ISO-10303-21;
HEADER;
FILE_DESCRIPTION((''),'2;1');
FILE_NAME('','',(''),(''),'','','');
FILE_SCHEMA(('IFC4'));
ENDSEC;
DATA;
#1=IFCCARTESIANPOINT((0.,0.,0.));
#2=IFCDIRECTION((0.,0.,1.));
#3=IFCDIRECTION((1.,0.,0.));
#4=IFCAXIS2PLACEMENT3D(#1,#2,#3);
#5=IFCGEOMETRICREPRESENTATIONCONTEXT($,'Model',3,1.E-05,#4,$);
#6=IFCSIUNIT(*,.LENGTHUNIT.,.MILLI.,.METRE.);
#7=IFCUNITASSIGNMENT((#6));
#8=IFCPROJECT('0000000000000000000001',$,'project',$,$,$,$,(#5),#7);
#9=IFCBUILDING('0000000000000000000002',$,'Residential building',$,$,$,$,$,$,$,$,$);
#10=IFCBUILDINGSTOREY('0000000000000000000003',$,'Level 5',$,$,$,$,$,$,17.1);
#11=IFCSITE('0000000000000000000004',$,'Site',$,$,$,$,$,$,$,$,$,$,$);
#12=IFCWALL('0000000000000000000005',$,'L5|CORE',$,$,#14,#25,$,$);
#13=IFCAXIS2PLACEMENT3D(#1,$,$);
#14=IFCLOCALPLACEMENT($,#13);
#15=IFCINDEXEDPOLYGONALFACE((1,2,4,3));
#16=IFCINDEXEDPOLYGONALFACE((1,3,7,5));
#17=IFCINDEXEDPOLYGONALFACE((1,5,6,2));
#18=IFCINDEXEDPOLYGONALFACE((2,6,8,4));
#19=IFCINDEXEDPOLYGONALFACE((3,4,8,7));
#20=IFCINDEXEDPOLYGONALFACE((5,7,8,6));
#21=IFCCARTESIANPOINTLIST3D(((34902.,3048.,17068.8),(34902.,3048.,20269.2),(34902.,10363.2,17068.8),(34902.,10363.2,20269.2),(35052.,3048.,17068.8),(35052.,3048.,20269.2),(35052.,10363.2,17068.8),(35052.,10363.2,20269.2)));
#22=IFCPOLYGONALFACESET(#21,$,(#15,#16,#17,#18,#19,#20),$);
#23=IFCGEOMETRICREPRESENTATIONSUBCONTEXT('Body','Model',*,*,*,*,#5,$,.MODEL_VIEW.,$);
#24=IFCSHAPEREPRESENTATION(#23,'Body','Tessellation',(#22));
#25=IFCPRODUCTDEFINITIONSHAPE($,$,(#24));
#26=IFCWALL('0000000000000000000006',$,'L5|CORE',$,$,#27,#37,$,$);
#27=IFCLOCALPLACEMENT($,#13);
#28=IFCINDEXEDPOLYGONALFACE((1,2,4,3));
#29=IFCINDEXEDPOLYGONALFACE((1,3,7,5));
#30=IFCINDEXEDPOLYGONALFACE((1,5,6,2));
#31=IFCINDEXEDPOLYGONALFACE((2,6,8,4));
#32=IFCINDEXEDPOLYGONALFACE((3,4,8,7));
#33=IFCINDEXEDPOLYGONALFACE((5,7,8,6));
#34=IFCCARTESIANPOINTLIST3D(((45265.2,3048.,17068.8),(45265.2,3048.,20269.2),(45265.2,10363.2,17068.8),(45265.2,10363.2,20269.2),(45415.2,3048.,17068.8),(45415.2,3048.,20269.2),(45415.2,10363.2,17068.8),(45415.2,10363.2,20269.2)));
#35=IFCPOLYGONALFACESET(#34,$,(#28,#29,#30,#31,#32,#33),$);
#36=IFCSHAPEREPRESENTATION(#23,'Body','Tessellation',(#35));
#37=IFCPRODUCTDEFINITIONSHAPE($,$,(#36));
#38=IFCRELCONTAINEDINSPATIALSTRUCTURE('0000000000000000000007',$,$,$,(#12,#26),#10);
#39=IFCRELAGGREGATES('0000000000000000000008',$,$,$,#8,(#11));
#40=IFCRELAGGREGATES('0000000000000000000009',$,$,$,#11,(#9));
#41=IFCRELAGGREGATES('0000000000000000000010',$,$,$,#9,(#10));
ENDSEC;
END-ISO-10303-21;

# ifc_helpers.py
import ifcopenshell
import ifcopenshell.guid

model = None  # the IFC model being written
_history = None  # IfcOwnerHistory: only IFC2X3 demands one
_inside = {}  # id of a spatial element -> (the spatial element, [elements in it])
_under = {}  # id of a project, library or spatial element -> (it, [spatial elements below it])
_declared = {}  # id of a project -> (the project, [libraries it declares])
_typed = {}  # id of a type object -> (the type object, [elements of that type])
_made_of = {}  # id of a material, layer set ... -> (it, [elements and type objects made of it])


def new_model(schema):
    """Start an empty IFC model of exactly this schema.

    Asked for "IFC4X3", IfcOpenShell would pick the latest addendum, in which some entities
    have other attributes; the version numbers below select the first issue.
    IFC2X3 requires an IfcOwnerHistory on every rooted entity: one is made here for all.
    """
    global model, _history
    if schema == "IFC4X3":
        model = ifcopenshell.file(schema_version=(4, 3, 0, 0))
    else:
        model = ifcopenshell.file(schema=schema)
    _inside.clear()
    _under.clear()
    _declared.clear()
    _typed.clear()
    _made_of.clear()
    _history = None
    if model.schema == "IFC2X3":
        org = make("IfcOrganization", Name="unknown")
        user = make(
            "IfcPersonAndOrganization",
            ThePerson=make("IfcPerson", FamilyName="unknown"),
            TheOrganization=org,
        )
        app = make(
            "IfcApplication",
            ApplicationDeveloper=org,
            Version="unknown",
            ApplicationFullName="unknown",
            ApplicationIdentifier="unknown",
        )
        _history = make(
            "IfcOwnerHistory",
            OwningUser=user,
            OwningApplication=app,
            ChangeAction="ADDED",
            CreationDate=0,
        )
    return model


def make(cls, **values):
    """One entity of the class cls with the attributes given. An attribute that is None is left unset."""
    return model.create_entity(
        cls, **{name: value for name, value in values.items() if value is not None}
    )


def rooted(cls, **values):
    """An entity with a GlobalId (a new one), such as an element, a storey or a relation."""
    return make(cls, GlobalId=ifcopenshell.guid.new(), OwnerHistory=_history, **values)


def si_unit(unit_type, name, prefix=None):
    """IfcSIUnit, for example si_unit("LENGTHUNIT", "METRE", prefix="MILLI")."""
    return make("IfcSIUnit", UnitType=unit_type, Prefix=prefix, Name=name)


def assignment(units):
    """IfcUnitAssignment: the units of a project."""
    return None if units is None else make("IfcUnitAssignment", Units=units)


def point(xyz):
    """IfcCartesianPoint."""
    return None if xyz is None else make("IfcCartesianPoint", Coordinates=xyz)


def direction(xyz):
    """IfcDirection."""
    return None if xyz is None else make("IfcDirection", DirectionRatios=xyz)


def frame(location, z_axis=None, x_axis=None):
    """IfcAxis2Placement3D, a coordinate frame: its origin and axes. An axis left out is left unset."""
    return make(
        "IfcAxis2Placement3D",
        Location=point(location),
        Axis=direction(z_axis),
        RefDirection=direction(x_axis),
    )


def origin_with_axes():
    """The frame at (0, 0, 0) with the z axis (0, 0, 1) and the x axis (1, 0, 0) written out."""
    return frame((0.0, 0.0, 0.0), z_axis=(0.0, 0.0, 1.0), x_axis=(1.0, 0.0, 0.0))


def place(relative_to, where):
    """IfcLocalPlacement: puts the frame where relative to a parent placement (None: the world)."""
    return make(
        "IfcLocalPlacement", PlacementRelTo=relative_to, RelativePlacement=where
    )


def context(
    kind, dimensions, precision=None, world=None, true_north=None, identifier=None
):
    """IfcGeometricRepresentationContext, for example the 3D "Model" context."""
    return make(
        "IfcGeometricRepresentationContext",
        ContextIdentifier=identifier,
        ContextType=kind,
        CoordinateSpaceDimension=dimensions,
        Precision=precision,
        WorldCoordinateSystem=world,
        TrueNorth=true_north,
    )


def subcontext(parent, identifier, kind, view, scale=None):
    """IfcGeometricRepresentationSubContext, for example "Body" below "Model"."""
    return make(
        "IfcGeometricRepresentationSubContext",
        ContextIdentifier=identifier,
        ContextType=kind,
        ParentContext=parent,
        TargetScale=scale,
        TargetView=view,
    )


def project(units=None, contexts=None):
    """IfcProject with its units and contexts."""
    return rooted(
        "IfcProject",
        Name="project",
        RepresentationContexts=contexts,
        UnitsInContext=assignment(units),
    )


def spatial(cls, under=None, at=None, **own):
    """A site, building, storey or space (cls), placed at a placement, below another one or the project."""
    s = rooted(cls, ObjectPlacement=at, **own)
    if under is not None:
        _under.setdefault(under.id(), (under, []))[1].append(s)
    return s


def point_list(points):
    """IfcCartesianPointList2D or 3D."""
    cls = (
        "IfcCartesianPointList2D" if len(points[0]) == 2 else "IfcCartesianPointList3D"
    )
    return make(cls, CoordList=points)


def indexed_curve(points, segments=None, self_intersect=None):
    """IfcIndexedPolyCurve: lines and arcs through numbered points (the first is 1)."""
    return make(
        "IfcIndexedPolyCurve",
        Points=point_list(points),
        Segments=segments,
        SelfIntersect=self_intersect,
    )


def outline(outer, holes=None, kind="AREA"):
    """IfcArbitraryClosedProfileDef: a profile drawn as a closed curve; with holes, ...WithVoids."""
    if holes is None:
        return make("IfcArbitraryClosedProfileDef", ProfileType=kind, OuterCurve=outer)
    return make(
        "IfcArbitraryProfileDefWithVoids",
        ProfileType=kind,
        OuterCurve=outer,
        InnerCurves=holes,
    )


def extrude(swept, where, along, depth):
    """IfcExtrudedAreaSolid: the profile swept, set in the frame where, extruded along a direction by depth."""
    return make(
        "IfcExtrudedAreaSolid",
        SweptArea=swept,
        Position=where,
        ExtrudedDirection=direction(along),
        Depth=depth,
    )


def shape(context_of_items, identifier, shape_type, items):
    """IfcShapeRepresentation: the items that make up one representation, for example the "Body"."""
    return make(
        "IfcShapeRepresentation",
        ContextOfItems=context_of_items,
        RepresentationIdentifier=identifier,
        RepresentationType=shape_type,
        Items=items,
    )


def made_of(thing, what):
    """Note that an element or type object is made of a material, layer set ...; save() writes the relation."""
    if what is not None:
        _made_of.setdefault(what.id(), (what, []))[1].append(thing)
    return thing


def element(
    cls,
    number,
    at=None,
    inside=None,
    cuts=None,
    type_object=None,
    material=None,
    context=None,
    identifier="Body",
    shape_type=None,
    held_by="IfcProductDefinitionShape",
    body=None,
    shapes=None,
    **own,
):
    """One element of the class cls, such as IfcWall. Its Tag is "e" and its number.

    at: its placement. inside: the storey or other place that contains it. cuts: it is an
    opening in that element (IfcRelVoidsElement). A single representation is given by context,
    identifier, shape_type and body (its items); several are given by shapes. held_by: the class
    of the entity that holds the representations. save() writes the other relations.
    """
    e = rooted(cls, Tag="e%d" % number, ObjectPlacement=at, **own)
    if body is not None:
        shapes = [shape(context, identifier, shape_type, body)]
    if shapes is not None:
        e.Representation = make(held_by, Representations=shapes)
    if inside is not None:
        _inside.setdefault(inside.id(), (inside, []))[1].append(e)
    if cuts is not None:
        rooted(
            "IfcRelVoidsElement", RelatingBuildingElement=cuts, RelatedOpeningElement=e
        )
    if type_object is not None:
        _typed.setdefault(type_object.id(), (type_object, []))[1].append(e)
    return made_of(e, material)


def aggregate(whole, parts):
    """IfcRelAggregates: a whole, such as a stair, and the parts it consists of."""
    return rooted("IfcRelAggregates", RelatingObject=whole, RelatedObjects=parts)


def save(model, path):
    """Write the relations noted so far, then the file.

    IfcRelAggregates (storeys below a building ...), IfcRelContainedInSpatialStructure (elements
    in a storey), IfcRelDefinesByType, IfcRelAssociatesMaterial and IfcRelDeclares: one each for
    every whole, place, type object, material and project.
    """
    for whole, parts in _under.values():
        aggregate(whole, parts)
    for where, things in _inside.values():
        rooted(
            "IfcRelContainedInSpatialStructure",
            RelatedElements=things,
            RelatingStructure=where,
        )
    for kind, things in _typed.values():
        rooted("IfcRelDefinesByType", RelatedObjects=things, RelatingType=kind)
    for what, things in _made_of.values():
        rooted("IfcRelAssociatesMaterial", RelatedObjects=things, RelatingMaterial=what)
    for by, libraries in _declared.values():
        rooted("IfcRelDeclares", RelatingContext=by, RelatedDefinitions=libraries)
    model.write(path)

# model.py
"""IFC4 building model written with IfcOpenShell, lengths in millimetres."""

from ifc_helpers import new_model, si_unit, frame, origin_with_axes, place, context, subcontext, project, spatial, indexed_curve, outline, extrude, element, save


model = new_model("IFC4")

# Units and contexts
model_context = context("Model", 3, precision=1e-05, world=origin_with_axes())
body_context = subcontext(model_context, "Body", "Model", "MODEL_VIEW")
ifc_project = project(units=[si_unit("LENGTHUNIT", "METRE", prefix="MILLI")], contexts=[model_context])

# Site, building, storey
site = spatial("IfcSite", under=ifc_project, Name="Site")
building = spatial("IfcBuilding", under=site, Name="Residential building")
storey = spatial("IfcBuildingStorey", under=building, Name="Level 5", Elevation=17.1)

# Walls
for number, where, z_axis, x_axis, name in (
    (1, (35052.0, 3048.0, 17068.8), (0.0, 0.0, 1.0), (0.0, 1.0, 0.0), "L5|CORE"),
    (2, (45415.2, 3048.0, 17068.8), (0.0, 0.0, 1.0), (0.0, 1.0, 0.0), "L5|CORE"),
):
    element("IfcWall", number, at=place(None, frame(where, z_axis=z_axis, x_axis=x_axis)), inside=storey, Name=name, context=body_context, shape_type="SweptSolid", body=[
        extrude(outline(indexed_curve([(0.0, 0.0), (0.0, 150.0), (7315.2, 150.0), (7315.2, 0.0), (0.0, 0.0)], self_intersect=False)), origin_with_axes(), (0.0, 0.0, 1.0), 3200.4),
    ])

save(model, "model.ifc")
